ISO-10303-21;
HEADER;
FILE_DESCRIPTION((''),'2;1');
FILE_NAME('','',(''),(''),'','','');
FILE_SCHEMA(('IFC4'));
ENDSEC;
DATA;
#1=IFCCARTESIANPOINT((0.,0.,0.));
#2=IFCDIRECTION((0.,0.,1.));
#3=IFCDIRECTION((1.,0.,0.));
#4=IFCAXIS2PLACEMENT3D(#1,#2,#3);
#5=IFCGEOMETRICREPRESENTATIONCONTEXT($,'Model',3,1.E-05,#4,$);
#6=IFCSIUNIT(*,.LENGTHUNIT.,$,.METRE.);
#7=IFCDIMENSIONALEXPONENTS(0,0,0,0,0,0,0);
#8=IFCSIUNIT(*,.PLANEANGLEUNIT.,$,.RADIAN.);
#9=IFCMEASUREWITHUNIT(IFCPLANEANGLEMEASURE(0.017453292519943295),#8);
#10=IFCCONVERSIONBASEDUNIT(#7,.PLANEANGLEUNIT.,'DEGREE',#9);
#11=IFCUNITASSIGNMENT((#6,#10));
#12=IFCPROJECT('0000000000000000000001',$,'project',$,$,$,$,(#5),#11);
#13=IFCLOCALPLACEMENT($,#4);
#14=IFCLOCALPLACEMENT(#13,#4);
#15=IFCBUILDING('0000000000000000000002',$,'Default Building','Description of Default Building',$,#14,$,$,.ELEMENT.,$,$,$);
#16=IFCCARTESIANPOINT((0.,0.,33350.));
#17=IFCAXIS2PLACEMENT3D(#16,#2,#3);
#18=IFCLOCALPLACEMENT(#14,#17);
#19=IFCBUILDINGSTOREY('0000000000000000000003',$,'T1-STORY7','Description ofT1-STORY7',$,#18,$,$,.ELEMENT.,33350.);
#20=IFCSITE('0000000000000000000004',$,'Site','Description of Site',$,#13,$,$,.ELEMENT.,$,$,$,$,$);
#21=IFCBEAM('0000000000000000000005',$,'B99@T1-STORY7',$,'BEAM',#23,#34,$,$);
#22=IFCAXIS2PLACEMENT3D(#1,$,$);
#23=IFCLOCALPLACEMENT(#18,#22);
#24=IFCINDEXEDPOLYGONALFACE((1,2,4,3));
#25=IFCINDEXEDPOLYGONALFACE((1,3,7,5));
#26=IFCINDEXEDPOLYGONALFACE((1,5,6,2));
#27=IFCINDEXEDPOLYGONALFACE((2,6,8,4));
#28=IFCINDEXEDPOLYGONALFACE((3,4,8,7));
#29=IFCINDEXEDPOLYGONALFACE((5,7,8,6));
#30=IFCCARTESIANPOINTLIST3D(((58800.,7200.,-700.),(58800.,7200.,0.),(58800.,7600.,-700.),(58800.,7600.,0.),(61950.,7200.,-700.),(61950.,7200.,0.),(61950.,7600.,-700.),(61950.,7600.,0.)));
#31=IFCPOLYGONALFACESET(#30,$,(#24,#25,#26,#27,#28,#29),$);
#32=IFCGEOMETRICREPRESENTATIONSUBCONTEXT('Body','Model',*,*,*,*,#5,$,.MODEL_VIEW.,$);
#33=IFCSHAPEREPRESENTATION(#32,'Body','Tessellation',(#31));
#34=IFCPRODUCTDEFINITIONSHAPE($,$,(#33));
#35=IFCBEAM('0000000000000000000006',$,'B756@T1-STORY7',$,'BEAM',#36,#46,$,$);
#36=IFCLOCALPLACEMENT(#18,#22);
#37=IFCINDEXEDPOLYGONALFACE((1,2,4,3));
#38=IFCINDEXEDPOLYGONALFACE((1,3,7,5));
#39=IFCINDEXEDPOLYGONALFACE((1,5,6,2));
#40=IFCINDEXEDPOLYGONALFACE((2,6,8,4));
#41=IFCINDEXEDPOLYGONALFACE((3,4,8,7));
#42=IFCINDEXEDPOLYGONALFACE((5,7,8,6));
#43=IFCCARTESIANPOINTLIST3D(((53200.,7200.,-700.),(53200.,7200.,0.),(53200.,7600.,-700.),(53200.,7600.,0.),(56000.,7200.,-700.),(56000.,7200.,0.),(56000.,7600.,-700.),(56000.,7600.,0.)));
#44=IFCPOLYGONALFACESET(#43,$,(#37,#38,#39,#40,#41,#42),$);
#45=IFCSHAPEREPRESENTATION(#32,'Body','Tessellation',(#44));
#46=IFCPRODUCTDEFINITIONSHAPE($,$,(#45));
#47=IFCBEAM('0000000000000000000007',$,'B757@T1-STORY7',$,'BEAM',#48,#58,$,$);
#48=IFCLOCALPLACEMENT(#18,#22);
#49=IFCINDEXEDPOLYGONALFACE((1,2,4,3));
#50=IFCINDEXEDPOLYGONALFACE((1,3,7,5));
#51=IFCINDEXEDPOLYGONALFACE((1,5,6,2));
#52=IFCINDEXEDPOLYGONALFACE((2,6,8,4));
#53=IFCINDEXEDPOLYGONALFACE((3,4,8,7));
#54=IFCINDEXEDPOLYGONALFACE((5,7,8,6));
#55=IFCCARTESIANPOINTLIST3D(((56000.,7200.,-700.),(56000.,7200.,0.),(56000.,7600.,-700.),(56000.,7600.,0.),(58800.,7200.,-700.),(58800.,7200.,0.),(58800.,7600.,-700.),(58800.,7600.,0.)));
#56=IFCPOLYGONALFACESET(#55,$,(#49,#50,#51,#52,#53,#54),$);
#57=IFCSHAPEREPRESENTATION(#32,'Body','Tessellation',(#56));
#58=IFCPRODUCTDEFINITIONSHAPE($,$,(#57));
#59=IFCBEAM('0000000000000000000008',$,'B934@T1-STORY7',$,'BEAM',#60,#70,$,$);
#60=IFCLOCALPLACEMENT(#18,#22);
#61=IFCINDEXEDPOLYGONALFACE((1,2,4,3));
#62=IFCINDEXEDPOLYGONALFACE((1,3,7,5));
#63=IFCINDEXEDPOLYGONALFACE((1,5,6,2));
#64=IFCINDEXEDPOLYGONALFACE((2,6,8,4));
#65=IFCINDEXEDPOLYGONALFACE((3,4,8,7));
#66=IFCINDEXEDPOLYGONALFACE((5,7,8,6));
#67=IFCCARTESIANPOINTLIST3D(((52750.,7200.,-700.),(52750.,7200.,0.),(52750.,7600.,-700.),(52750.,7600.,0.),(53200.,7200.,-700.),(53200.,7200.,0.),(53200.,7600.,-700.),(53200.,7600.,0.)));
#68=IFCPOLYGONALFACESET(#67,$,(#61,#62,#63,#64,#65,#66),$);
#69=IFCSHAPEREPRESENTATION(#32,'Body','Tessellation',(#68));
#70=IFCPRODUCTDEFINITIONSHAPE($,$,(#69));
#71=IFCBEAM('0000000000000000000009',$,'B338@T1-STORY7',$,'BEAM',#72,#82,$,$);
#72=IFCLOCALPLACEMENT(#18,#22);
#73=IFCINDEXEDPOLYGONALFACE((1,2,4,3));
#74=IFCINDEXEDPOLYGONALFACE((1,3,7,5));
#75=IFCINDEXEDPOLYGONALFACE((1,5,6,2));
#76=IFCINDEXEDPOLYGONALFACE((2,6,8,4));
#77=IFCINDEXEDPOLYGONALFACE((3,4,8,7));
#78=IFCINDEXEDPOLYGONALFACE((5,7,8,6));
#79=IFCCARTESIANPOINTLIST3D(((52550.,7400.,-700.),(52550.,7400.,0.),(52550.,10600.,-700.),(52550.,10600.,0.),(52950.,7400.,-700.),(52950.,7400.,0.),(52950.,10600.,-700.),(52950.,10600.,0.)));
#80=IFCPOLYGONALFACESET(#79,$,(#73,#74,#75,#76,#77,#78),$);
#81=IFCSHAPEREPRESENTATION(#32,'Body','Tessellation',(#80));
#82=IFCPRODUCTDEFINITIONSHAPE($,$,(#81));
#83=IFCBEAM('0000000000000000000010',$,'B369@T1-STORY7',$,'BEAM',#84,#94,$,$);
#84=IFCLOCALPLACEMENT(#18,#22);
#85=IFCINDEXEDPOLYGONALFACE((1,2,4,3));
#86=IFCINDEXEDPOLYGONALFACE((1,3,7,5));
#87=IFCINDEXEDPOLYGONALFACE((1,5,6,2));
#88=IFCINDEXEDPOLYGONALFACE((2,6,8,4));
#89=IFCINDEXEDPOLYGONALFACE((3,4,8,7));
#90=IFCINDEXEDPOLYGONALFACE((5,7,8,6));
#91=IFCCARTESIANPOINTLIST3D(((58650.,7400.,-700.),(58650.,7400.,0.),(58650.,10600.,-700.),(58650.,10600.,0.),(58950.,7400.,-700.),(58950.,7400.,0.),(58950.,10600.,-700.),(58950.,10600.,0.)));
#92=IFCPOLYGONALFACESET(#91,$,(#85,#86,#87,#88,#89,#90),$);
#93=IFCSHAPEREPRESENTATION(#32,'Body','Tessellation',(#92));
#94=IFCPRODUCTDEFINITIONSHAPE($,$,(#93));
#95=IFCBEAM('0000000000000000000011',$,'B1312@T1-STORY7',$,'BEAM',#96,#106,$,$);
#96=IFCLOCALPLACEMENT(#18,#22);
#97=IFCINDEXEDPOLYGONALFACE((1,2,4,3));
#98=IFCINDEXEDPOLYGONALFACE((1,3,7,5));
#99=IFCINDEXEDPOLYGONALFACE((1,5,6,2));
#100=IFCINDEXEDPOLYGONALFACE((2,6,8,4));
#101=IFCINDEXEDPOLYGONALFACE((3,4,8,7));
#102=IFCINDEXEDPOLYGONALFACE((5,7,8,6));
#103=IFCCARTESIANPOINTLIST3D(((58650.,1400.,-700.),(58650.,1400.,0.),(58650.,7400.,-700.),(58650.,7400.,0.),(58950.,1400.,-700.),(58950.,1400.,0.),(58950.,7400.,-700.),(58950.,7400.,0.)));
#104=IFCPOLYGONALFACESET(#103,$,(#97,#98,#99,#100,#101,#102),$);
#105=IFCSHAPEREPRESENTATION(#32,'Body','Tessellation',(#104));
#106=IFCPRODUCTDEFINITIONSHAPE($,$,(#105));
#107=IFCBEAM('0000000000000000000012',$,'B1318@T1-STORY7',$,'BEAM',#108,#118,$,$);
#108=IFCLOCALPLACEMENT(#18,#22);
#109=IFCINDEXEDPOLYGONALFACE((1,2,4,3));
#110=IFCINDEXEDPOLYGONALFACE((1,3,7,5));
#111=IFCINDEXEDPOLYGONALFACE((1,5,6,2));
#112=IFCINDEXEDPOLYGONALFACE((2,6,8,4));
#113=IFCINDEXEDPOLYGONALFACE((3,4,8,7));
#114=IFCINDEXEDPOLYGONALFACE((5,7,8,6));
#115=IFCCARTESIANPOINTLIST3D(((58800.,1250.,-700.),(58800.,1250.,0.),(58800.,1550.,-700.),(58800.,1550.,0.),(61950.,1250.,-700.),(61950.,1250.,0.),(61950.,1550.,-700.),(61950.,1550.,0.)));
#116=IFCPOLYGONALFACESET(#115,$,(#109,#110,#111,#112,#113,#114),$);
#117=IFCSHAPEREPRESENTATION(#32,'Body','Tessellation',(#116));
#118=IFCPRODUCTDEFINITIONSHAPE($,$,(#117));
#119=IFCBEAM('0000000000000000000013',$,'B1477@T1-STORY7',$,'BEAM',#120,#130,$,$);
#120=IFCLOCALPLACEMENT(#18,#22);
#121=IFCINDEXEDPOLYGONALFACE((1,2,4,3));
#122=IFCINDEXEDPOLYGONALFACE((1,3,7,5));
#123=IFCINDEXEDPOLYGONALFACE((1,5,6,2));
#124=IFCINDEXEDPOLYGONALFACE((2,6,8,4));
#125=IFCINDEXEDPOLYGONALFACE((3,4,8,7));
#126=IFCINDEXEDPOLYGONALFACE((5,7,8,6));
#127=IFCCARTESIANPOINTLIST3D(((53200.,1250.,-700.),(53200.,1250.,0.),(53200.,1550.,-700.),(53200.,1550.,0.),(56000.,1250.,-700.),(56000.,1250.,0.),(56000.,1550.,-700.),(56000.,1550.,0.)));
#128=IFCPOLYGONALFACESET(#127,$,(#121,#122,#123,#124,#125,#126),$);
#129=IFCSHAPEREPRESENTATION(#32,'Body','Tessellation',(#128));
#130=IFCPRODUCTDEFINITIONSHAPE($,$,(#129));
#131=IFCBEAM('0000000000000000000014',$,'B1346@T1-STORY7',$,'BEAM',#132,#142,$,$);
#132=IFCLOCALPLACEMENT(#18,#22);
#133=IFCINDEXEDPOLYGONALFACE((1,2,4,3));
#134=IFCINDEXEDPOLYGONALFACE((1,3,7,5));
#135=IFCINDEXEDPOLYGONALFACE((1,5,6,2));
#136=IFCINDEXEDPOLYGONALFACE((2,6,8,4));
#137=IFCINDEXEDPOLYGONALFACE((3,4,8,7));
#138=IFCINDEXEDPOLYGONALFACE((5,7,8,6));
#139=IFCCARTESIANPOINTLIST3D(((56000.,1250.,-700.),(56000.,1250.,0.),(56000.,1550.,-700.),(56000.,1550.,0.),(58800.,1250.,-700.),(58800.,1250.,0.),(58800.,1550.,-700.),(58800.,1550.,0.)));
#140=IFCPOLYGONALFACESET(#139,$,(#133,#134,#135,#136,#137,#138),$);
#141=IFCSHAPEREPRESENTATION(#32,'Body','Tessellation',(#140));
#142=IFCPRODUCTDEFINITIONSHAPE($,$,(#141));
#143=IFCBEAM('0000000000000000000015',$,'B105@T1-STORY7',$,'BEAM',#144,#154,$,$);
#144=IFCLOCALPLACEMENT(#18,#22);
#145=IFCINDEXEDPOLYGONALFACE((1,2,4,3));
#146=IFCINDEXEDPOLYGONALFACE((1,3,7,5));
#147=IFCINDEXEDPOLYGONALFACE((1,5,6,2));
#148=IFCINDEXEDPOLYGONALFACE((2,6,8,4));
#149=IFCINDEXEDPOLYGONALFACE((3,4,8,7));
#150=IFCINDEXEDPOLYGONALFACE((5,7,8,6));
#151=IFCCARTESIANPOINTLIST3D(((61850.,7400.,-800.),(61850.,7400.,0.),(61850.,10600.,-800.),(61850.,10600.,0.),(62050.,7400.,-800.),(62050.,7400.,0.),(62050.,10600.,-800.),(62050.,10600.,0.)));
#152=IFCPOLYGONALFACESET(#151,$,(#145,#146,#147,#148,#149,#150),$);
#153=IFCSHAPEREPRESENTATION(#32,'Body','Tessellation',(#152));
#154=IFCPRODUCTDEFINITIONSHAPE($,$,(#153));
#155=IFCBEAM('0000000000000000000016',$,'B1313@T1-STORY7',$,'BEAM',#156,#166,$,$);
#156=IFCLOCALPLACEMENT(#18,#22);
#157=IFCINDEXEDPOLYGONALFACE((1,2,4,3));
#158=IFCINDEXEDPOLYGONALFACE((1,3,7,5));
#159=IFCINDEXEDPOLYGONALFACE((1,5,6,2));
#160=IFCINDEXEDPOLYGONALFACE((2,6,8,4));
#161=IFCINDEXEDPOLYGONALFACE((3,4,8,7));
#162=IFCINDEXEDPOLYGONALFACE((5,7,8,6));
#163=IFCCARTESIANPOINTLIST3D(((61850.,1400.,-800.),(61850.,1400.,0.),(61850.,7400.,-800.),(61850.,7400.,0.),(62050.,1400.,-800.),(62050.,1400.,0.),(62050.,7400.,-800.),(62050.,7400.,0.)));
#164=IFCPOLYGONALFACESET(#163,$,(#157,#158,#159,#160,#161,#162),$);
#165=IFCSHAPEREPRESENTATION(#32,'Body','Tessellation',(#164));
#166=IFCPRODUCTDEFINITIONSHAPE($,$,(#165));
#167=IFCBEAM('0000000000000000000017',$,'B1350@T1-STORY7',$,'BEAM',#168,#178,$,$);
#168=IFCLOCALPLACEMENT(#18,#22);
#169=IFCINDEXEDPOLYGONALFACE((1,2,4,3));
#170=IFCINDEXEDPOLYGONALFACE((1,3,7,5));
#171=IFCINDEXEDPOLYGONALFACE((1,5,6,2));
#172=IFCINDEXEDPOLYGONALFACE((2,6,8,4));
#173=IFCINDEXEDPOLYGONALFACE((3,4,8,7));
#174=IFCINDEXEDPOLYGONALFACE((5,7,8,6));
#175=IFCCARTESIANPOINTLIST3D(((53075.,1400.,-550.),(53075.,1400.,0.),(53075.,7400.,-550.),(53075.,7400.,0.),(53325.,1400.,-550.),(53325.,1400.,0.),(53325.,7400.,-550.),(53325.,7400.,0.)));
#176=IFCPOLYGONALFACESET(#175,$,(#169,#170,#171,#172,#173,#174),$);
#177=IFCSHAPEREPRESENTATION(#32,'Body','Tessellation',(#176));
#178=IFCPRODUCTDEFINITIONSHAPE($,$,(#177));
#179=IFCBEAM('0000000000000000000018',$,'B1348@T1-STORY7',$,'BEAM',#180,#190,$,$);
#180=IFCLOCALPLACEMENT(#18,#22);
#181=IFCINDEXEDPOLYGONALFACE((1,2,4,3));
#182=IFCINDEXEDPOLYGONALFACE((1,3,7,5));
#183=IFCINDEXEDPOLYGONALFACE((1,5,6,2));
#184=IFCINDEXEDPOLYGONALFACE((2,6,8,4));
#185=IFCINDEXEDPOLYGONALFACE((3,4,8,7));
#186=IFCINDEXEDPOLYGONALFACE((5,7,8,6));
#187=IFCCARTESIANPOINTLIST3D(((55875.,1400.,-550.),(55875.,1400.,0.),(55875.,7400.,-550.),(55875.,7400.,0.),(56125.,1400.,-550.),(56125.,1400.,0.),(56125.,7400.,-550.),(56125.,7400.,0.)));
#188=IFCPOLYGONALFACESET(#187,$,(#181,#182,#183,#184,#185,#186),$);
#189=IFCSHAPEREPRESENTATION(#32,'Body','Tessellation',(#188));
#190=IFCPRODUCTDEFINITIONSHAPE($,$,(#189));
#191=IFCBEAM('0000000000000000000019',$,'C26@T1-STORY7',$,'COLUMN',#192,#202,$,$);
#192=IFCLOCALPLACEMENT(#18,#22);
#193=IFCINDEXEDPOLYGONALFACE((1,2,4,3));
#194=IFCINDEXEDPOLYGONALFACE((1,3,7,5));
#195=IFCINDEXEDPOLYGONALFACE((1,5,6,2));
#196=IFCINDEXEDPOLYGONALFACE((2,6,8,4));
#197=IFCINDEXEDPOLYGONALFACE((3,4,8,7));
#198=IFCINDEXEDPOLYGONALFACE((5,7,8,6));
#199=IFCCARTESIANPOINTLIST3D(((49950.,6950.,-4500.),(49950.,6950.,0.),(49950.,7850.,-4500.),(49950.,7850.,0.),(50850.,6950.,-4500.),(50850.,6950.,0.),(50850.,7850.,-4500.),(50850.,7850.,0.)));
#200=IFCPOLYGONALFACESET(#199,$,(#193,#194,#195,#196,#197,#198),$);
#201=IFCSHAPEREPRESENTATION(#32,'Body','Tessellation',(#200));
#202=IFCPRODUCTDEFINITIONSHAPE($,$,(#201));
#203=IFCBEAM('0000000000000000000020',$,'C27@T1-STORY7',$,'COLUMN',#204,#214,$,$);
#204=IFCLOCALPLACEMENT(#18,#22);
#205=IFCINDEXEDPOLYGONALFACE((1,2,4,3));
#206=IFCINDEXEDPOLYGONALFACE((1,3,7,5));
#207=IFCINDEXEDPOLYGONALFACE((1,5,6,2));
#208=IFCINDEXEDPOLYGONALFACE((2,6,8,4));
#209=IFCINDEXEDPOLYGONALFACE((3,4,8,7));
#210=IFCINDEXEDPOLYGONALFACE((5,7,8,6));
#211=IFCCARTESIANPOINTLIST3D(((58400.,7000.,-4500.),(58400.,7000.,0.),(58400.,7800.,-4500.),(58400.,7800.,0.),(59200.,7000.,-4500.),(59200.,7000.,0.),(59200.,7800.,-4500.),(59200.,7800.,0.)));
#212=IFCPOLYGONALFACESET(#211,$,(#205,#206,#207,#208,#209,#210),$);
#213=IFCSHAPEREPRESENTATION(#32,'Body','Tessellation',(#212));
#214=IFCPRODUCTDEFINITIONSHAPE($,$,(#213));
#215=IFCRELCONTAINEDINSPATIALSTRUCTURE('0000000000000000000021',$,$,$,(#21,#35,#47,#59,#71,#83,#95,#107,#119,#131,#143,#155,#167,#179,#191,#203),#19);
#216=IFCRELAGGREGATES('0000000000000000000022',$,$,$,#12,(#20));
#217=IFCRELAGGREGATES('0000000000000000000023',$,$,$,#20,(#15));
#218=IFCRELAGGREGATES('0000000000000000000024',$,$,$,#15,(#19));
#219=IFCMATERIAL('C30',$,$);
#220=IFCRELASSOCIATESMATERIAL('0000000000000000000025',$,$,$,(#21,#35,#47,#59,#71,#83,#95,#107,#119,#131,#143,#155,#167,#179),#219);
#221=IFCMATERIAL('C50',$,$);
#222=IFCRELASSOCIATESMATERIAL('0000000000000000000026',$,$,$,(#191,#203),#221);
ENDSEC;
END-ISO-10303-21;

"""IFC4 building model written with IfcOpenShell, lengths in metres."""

from ifc_helpers import new_model, entity, si_unit, converted_unit, frame, origin_with_axes, place, context, subcontext, project, spatial, rectangle, extrude, material, element, save


model = new_model("IFC4")

# Units and contexts
model_context = context("Model", 3, precision=1e-05, world=origin_with_axes())
body_context = subcontext(model_context, "Body", "Model", "MODEL_VIEW")
ifc_project = project(units=[si_unit("LENGTHUNIT", "METRE"), converted_unit("PLANEANGLEUNIT", "DEGREE", entity("IfcPlaneAngleMeasure", 0.017453292519943295), si_unit("PLANEANGLEUNIT", "RADIAN"), dimensions=[0, 0, 0, 0, 0, 0, 0])], contexts=[model_context])

# Site, building, storey
site_placement = place(None, origin_with_axes())
site = spatial("IfcSite", under=ifc_project, at=site_placement, Name="Site", Description="Description of Site", CompositionType="ELEMENT")
building_placement = place(site_placement, origin_with_axes())
building = spatial("IfcBuilding", under=site, at=building_placement, Name="Default Building", Description="Description of Default Building", CompositionType="ELEMENT")
storey_placement = place(building_placement, frame((0.0, 0.0, 33350.0), z_axis=(0.0, 0.0, 1.0), x_axis=(1.0, 0.0, 0.0)))
storey = spatial("IfcBuildingStorey", under=building, at=storey_placement, Name="T1-STORY7", Description="Description ofT1-STORY7", CompositionType="ELEMENT", Elevation=33350.0)

# Beams
ifc_material_1 = material(Name="C30")
beam_1_placement = place(storey_placement, frame((58800.0, 7400.0, -350.0), z_axis=(1.0, 0.0, 0.0), x_axis=(0.0, 1.0, 0.0)))
element("IfcBeam", 1, at=beam_1_placement, inside=storey, material=ifc_material_1, Name="B99@T1-STORY7", ObjectType="BEAM", context=body_context, shape_type="SweptSolid", body=[
    extrude(rectangle(XDim=400.0, YDim=700.0), origin_with_axes(), (0.0, 0.0, 1.0), 3150.0),
])
for number, where, z_axis, x_axis, name in (
    (2, (53200.0, 7400.0, -350.0), (1.0, 0.0, 0.0), (0.0, 1.0, 0.0), "B756@T1-STORY7"),
    (3, (56000.0, 7400.0, -350.0), (1.0, 0.0, 0.0), (0.0, 1.0, 0.0), "B757@T1-STORY7"),
):
    element("IfcBeam", number, at=place(storey_placement, frame(where, z_axis=z_axis, x_axis=x_axis)), inside=storey, material=ifc_material_1, Name=name, ObjectType="BEAM", context=body_context, shape_type="SweptSolid", body=[
        extrude(rectangle(XDim=400.0, YDim=700.0), origin_with_axes(), (0.0, 0.0, 1.0), 2800.0),
    ])
beam_2_placement = place(storey_placement, frame((52750.0, 7400.0, -350.0), z_axis=(1.0, 0.0, 0.0), x_axis=(0.0, 1.0, 0.0)))
element("IfcBeam", 4, at=beam_2_placement, inside=storey, material=ifc_material_1, Name="B934@T1-STORY7", ObjectType="BEAM", context=body_context, shape_type="SweptSolid", body=[
    extrude(rectangle(XDim=400.0, YDim=700.0), origin_with_axes(), (0.0, 0.0, 1.0), 450.0),
])
beam_3_placement = place(storey_placement, frame((52750.0, 7400.0, -350.0), z_axis=(0.0, 1.0, 0.0), x_axis=(-1.0, 0.0, 0.0)))
element("IfcBeam", 5, at=beam_3_placement, inside=storey, material=ifc_material_1, Name="B338@T1-STORY7", ObjectType="BEAM", context=body_context, shape_type="SweptSolid", body=[
    extrude(rectangle(XDim=400.0, YDim=700.0), origin_with_axes(), (0.0, 0.0, 1.0), 3200.0),
])
beam_4_placement = place(storey_placement, frame((58800.0, 7400.0, -350.0), z_axis=(0.0, 1.0, 0.0), x_axis=(-1.0, 0.0, 0.0)))
element("IfcBeam", 6, at=beam_4_placement, inside=storey, material=ifc_material_1, Name="B369@T1-STORY7", ObjectType="BEAM", context=body_context, shape_type="SweptSolid", body=[
    extrude(rectangle(XDim=300.0, YDim=700.0), origin_with_axes(), (0.0, 0.0, 1.0), 3200.0),
])
beam_5_placement = place(storey_placement, frame((58800.0, 1400.0, -350.0), z_axis=(0.0, 1.0, 0.0), x_axis=(-1.0, 0.0, 0.0)))
element("IfcBeam", 7, at=beam_5_placement, inside=storey, material=ifc_material_1, Name="B1312@T1-STORY7", ObjectType="BEAM", context=body_context, shape_type="SweptSolid", body=[
    extrude(rectangle(XDim=300.0, YDim=700.0), origin_with_axes(), (0.0, 0.0, 1.0), 6000.0),
])
beam_6_placement = place(storey_placement, frame((58800.0, 1400.0, -350.0), z_axis=(1.0, 0.0, 0.0), x_axis=(0.0, 1.0, 0.0)))
element("IfcBeam", 8, at=beam_6_placement, inside=storey, material=ifc_material_1, Name="B1318@T1-STORY7", ObjectType="BEAM", context=body_context, shape_type="SweptSolid", body=[
    extrude(rectangle(XDim=300.0, YDim=700.0), origin_with_axes(), (0.0, 0.0, 1.0), 3150.0),
])
for number, where, z_axis, x_axis, name in (
    (9, (53200.0, 1400.0, -350.0), (1.0, 0.0, 0.0), (0.0, 1.0, 0.0), "B1477@T1-STORY7"),
    (10, (56000.0, 1400.0, -350.0), (1.0, 0.0, 0.0), (0.0, 1.0, 0.0), "B1346@T1-STORY7"),
):
    element("IfcBeam", number, at=place(storey_placement, frame(where, z_axis=z_axis, x_axis=x_axis)), inside=storey, material=ifc_material_1, Name=name, ObjectType="BEAM", context=body_context, shape_type="SweptSolid", body=[
        extrude(rectangle(XDim=300.0, YDim=700.0), origin_with_axes(), (0.0, 0.0, 1.0), 2800.0),
    ])
beam_7_placement = place(storey_placement, frame((61950.0, 7400.0, -400.0), z_axis=(0.0, 1.0, 0.0), x_axis=(-1.0, 0.0, 0.0)))
element("IfcBeam", 11, at=beam_7_placement, inside=storey, material=ifc_material_1, Name="B105@T1-STORY7", ObjectType="BEAM", context=body_context, shape_type="SweptSolid", body=[
    extrude(rectangle(XDim=200.0, YDim=800.0), origin_with_axes(), (0.0, 0.0, 1.0), 3200.0),
])
beam_8_placement = place(storey_placement, frame((61950.0, 1400.0, -400.0), z_axis=(0.0, 1.0, 0.0), x_axis=(-1.0, 0.0, 0.0)))
element("IfcBeam", 12, at=beam_8_placement, inside=storey, material=ifc_material_1, Name="B1313@T1-STORY7", ObjectType="BEAM", context=body_context, shape_type="SweptSolid", body=[
    extrude(rectangle(XDim=200.0, YDim=800.0), origin_with_axes(), (0.0, 0.0, 1.0), 6000.0),
])
for number, where, z_axis, x_axis, name in (
    (13, (53200.0, 1400.0, -275.0), (0.0, 1.0, 0.0), (-1.0, 0.0, 0.0), "B1350@T1-STORY7"),
    (14, (56000.0, 1400.0, -275.0), (0.0, 1.0, 0.0), (-1.0, 0.0, 0.0), "B1348@T1-STORY7"),
):
    element("IfcBeam", number, at=place(storey_placement, frame(where, z_axis=z_axis, x_axis=x_axis)), inside=storey, material=ifc_material_1, Name=name, ObjectType="BEAM", context=body_context, shape_type="SweptSolid", body=[
        extrude(rectangle(XDim=250.0, YDim=550.0), origin_with_axes(), (0.0, 0.0, 1.0), 6000.0),
    ])
ifc_material_2 = material(Name="C50")
beam_9_placement = place(storey_placement, frame((50400.0, 7400.0, -4500.0), z_axis=(0.0, 0.0, 1.0), x_axis=(-1.0, 0.0, 0.0)))
element("IfcBeam", 15, at=beam_9_placement, inside=storey, material=ifc_material_2, Name="C26@T1-STORY7", ObjectType="COLUMN", context=body_context, shape_type="SweptSolid", body=[
    extrude(rectangle(XDim=900.0, YDim=900.0), origin_with_axes(), (0.0, 0.0, 1.0), 4500.0),
])
beam_10_placement = place(storey_placement, frame((58800.0, 7400.0, -4500.0), z_axis=(0.0, 0.0, 1.0), x_axis=(-1.0, 0.0, 0.0)))
element("IfcBeam", 16, at=beam_10_placement, inside=storey, material=ifc_material_2, Name="C27@T1-STORY7", ObjectType="COLUMN", context=body_context, shape_type="SweptSolid", body=[
    extrude(rectangle(XDim=800.0, YDim=800.0), origin_with_axes(), (0.0, 0.0, 1.0), 4500.0),
])

save(model, "model.ifc")
